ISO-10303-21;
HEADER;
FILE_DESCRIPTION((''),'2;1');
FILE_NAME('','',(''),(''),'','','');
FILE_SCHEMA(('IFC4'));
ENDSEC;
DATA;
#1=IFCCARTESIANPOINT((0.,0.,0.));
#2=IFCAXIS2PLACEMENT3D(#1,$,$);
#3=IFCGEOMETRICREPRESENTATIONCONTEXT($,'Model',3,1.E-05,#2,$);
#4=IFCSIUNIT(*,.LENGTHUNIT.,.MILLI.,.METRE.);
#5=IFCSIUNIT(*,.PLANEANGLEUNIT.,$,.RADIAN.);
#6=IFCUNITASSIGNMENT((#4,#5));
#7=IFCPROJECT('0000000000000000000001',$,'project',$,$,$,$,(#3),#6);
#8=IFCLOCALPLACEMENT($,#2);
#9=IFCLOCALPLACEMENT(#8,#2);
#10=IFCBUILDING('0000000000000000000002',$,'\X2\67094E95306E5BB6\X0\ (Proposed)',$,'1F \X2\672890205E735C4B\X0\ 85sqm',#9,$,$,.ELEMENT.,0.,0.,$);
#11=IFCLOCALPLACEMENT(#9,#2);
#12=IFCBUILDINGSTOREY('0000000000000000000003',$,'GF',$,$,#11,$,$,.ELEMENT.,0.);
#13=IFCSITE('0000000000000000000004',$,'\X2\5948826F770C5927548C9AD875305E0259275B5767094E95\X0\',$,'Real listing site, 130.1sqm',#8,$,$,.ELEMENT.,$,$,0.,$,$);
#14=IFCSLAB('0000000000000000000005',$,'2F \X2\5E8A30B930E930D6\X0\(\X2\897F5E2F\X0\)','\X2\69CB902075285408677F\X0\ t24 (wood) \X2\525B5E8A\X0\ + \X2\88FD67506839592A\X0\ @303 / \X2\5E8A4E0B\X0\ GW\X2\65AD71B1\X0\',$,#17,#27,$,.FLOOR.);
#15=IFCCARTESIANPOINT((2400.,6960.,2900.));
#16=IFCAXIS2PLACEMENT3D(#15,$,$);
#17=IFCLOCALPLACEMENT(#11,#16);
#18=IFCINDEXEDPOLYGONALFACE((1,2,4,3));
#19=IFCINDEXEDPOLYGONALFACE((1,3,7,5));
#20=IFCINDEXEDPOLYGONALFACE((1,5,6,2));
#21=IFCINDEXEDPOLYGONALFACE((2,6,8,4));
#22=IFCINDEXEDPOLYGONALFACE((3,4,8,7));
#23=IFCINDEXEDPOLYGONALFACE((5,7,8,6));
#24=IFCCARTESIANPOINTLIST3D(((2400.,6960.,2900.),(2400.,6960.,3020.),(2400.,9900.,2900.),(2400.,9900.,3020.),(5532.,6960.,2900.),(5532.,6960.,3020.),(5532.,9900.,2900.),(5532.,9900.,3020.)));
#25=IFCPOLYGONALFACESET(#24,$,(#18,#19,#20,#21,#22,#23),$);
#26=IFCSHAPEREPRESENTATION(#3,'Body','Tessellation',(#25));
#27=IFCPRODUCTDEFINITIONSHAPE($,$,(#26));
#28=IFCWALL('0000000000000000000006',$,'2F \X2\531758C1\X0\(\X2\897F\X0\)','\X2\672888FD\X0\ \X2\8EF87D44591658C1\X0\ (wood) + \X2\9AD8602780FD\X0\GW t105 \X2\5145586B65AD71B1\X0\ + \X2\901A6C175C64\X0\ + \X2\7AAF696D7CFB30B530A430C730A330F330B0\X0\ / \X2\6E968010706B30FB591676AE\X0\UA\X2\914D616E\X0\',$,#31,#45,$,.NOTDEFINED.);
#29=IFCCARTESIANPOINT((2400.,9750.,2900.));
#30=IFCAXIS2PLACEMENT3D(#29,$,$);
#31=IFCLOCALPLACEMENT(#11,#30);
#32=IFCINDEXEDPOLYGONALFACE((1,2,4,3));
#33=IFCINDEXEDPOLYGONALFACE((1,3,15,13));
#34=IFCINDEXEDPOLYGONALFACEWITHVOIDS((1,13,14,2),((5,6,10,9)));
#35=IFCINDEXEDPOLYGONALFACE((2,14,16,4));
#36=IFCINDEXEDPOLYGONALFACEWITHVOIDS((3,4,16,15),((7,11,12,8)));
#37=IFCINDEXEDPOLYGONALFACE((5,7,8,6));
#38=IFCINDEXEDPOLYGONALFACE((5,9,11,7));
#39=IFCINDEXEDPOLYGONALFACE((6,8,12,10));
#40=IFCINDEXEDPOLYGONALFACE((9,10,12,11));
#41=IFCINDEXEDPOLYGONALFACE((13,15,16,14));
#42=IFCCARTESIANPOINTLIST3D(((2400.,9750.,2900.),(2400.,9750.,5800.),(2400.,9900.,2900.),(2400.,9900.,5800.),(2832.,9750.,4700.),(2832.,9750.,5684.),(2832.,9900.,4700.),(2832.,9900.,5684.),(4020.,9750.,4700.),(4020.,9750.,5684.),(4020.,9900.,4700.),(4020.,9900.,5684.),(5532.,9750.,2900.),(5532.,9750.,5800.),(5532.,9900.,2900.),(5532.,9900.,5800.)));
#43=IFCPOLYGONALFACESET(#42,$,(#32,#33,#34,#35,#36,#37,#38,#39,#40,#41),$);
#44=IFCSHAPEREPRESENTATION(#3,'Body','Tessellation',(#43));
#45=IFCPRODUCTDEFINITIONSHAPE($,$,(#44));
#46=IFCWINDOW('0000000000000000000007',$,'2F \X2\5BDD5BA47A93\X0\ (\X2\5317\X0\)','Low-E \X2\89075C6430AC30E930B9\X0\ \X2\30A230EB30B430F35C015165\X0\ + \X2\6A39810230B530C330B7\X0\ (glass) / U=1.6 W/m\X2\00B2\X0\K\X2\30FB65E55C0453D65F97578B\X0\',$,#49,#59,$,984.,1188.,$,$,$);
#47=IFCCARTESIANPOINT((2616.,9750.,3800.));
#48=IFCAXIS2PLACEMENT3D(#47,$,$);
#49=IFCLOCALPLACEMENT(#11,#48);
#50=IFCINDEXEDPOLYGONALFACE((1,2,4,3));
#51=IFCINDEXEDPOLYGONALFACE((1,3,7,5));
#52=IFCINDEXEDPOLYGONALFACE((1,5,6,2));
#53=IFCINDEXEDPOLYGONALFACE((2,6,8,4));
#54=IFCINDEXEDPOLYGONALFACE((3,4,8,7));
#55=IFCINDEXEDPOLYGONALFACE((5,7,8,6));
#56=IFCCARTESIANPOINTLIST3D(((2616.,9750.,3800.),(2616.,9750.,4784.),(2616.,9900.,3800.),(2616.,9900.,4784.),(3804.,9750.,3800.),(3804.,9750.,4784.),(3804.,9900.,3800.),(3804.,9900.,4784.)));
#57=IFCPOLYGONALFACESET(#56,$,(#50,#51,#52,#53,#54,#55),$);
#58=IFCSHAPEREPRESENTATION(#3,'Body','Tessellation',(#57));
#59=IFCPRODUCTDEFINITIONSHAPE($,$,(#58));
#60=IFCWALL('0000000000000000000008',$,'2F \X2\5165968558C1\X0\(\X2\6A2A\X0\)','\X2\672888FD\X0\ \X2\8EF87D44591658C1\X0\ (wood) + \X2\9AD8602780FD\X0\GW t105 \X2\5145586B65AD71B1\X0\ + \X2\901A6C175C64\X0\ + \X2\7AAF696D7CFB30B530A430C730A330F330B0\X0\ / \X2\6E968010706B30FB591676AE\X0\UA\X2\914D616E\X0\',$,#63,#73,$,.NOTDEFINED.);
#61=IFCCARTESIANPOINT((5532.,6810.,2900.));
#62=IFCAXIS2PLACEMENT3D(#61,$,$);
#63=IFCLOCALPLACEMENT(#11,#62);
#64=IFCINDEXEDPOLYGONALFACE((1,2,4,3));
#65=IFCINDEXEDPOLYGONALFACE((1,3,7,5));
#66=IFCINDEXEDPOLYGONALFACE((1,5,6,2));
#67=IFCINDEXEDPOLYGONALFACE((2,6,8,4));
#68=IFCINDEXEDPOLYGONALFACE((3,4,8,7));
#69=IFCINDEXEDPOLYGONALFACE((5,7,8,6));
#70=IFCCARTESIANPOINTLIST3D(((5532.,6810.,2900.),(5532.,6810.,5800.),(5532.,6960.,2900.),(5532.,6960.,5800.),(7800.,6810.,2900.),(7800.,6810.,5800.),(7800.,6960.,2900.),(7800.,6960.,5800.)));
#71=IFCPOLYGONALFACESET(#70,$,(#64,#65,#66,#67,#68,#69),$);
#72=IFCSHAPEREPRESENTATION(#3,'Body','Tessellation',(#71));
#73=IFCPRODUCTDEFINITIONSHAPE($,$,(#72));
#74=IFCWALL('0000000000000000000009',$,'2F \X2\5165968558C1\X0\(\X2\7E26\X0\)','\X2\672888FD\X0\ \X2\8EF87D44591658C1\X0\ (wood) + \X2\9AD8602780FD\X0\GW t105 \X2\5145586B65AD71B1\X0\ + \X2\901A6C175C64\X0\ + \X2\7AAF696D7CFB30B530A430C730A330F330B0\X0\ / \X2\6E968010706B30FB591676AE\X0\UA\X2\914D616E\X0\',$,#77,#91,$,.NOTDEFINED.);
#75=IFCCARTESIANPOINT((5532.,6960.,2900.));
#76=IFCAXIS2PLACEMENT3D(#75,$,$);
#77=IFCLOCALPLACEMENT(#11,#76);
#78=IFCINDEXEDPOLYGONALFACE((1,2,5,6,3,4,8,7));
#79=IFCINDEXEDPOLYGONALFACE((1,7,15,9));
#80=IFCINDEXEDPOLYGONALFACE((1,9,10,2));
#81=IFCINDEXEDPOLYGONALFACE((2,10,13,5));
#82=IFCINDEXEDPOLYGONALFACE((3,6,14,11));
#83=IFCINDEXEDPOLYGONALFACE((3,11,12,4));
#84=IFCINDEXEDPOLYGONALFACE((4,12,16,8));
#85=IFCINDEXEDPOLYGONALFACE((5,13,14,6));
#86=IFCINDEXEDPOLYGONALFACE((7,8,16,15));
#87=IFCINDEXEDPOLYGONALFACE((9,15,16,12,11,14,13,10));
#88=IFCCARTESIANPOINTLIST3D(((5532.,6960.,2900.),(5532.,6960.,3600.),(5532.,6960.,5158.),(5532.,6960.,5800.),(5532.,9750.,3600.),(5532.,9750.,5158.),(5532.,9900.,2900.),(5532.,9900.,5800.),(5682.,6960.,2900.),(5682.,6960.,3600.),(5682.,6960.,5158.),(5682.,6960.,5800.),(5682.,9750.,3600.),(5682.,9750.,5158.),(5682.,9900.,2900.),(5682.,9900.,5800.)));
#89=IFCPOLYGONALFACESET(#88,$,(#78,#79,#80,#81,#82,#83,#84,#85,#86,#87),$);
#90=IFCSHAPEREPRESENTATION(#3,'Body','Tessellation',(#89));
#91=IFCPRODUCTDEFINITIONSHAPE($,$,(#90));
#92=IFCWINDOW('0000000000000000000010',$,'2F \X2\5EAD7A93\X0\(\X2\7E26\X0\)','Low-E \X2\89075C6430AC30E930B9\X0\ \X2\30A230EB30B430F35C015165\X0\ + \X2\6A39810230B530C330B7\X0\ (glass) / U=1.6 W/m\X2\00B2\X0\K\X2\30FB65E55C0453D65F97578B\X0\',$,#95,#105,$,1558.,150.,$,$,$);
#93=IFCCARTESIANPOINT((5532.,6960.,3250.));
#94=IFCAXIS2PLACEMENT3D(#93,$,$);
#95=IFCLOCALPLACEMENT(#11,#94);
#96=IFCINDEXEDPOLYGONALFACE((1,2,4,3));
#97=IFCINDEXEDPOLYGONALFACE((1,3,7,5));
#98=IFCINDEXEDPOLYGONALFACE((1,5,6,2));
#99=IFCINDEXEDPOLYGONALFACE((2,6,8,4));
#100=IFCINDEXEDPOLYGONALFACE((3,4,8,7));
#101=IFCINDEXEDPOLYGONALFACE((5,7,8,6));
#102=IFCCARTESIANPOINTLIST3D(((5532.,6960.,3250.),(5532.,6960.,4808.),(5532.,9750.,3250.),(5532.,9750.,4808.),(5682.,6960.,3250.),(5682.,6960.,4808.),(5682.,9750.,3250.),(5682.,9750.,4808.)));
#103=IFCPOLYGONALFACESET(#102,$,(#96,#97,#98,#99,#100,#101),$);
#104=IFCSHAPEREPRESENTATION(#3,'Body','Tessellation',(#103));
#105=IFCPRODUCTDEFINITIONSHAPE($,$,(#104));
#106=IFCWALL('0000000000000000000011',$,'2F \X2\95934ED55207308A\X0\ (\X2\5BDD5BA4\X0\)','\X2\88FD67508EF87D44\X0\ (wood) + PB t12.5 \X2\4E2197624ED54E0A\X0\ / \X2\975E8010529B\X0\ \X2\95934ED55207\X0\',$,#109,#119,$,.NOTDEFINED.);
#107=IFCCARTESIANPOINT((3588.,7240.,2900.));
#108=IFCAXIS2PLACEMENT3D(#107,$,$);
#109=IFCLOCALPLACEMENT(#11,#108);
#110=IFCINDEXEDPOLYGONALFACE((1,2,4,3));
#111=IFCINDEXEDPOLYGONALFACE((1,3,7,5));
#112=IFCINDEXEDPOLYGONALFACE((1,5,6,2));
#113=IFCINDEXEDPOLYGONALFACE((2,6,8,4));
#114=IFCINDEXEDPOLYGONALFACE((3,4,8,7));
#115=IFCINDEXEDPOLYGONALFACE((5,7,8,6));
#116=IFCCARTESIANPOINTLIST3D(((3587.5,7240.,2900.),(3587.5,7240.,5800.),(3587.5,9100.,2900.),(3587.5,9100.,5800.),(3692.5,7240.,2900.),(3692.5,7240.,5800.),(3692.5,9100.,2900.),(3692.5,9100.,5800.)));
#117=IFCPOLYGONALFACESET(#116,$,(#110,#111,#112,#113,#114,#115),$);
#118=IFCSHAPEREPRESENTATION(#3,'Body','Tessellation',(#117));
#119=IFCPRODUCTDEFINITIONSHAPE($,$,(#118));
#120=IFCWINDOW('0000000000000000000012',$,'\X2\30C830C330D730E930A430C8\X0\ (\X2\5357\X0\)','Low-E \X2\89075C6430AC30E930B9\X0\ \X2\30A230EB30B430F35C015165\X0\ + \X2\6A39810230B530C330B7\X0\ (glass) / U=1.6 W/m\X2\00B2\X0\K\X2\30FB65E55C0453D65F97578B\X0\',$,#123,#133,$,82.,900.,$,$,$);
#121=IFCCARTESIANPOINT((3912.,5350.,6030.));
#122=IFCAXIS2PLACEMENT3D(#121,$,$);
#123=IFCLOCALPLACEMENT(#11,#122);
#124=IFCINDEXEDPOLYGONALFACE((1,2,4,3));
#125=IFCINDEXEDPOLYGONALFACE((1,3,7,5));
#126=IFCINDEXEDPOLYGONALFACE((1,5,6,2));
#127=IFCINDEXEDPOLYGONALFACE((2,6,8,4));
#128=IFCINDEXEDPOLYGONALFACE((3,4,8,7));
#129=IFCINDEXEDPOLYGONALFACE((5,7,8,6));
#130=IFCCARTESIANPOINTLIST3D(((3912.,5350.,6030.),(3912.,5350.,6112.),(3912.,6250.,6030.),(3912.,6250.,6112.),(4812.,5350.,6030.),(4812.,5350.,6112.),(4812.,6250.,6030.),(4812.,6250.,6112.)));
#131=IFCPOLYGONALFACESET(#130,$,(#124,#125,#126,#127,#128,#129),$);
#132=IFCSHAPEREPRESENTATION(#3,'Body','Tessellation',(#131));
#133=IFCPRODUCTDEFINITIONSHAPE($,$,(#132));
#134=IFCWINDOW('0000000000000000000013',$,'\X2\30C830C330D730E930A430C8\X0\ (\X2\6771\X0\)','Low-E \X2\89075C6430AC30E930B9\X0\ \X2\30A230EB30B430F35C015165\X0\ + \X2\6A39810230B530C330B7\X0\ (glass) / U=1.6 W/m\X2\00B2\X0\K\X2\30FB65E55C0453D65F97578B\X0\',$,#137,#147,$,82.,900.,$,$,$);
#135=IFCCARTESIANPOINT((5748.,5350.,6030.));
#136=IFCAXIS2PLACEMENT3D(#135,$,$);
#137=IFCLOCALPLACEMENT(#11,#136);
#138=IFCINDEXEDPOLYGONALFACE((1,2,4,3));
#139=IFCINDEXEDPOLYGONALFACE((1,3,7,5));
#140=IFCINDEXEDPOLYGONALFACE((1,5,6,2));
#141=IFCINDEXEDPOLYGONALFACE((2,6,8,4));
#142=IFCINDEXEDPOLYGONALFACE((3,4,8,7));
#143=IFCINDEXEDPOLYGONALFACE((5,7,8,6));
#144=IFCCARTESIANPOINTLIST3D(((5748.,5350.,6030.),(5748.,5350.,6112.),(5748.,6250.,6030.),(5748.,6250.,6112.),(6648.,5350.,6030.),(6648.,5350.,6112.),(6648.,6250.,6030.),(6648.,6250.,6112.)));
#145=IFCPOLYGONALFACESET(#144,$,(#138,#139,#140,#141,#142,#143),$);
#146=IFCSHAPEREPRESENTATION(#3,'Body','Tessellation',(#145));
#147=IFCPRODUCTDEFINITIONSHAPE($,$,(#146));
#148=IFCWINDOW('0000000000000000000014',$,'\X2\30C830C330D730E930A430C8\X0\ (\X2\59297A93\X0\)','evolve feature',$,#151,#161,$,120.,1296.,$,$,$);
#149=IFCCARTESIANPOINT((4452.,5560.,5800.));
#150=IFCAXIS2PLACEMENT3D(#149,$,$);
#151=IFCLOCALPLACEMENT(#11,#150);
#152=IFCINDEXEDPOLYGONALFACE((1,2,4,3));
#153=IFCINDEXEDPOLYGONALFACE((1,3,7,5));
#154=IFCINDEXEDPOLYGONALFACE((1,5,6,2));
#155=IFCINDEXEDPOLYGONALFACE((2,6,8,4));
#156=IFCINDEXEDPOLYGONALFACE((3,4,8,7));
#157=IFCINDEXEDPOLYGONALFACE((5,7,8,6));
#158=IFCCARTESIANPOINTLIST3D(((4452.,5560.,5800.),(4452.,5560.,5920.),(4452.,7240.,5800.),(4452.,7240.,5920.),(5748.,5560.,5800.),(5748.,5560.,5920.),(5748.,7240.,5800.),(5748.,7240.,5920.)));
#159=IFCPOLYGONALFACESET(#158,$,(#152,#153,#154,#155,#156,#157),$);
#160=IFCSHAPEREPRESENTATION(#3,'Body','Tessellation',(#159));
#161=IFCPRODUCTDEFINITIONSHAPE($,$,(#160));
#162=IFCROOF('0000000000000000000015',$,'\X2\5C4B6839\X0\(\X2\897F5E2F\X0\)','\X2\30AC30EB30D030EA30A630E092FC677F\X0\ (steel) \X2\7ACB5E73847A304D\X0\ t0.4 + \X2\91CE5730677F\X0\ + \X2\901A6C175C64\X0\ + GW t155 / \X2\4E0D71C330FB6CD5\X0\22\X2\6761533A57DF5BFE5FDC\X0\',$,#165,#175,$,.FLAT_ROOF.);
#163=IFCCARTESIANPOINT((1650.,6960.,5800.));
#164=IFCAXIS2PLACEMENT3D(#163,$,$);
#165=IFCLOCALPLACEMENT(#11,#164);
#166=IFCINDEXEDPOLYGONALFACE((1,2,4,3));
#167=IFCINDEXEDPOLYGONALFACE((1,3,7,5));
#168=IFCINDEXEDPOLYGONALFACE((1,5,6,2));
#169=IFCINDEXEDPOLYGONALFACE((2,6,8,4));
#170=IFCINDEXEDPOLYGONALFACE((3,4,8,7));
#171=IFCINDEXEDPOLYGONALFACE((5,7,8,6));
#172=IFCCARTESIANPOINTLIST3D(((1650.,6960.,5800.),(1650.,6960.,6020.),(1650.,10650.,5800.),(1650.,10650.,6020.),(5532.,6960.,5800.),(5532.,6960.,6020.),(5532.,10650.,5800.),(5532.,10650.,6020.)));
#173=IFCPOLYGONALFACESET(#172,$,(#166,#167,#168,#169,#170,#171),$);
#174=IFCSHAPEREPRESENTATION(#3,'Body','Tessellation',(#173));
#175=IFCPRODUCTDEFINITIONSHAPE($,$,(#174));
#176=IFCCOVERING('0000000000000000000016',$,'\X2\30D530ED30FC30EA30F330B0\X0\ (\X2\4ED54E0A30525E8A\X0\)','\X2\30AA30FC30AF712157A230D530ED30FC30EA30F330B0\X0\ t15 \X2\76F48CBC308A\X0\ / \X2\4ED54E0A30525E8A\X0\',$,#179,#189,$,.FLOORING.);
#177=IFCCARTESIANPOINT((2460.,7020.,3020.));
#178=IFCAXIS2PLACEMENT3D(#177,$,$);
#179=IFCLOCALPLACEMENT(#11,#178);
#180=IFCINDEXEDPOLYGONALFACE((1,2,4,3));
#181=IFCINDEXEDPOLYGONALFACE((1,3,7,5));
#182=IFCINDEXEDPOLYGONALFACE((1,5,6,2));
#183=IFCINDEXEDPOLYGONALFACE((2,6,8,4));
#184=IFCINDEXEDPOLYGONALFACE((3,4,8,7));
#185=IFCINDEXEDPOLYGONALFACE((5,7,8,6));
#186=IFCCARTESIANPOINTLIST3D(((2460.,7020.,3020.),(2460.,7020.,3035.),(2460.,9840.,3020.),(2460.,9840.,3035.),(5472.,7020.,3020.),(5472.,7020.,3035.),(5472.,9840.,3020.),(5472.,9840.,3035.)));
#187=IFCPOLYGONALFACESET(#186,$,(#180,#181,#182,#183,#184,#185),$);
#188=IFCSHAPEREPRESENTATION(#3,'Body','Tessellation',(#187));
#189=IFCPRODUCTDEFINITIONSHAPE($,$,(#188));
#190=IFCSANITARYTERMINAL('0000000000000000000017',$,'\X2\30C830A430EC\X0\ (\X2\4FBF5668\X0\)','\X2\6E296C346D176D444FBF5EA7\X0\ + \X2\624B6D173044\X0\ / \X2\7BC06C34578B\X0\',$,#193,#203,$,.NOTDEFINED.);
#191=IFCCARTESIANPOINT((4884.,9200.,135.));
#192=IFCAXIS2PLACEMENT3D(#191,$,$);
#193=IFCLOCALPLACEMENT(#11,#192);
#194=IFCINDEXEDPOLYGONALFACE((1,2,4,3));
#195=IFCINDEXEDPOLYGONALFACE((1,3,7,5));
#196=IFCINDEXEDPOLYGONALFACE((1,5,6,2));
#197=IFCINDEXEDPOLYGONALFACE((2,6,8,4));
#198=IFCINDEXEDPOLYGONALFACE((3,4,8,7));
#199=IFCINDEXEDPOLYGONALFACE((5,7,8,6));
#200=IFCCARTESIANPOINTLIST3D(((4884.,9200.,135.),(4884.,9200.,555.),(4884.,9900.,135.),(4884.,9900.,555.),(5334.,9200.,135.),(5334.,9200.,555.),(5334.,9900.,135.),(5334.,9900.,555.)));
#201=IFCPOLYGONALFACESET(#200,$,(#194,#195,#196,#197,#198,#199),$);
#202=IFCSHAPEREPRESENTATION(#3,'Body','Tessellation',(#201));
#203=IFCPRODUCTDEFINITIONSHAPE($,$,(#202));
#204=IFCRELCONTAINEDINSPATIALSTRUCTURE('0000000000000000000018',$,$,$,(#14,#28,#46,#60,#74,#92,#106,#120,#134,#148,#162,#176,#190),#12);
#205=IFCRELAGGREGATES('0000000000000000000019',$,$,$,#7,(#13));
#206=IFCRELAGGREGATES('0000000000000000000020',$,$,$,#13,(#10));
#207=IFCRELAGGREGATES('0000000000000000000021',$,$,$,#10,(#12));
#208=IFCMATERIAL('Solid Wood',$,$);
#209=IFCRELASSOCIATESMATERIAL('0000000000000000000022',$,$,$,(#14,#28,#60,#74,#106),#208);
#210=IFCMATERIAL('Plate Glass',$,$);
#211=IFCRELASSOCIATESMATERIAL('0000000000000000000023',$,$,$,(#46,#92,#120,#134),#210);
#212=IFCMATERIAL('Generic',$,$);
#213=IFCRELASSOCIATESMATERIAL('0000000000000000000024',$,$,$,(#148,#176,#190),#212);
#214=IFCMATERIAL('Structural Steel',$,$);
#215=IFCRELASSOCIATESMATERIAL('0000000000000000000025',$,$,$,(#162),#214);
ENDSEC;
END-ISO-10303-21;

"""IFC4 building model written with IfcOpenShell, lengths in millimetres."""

from ifc_helpers import new_model, si_unit, frame, frame_2d, origin, place, context, project, spatial, rectangle, extrude, material, element, fill, save


model = new_model("IFC4")

# Units and contexts
model_context = context("Model", 3, precision=1e-05, world=origin())
ifc_project = project(units=[si_unit("LENGTHUNIT", "METRE", prefix="MILLI"), si_unit("PLANEANGLEUNIT", "RADIAN")], contexts=[model_context])

# Site, building, storey
site_placement = place(None, origin())
site = spatial("IfcSite", under=ifc_project, at=site_placement, Name="奈良県大和高田市大字有井", ObjectType="Real listing site, 130.1sqm", CompositionType="ELEMENT", RefElevation=0.0)
building_placement = place(site_placement, origin())
building = spatial("IfcBuilding", under=site, at=building_placement, Name="有井の家 (Proposed)", ObjectType="1F 木造平屋 85sqm", CompositionType="ELEMENT", ElevationOfRefHeight=0.0, ElevationOfTerrain=0.0)
storey_placement = place(building_placement, origin())
storey = spatial("IfcBuildingStorey", under=building, at=storey_placement, Name="GF", CompositionType="ELEMENT", Elevation=0.0)

# Slab
ifc_material_1 = material(Name="Solid Wood")
slab_placement = place(storey_placement, frame((2400.0, 6960.0, 2900.0)))
element("IfcSlab", 1, at=slab_placement, inside=storey, material=ifc_material_1, Name="2F 床スラブ(西帯)", Description="構造用合板 t24 (wood) 剛床 + 製材根太 @303 / 床下 GW断熱", PredefinedType="FLOOR", context=model_context, shape_type="SweptSolid", body=[
    extrude(rectangle(XDim=3132.0, YDim=2940.0, at=frame_2d((1566.0, 1470.0))), frame((2400.0, 6960.0, 2900.0)), (0.0, 0.0, 1.0), 120.0),
])

# Wall, opening, window
wall_1_placement = place(storey_placement, frame((2400.0, 9750.0, 2900.0)))
wall_1 = element("IfcWall", 2, at=wall_1_placement, inside=storey, material=ifc_material_1, Name="2F 北壁(西)", Description="木製 軸組外壁 (wood) + 高性能GW t105 充填断熱 + 通気層 + 窯業系サイディング / 準耐火・外皮UA配慮", PredefinedType="NOTDEFINED", context=model_context, shape_type="SweptSolid", body=[
    extrude(rectangle(XDim=3132.0, YDim=150.0, at=frame_2d((1566.0, 75.0))), frame((2400.0, 9750.0, 2900.0)), (0.0, 0.0, 1.0), 2900.0),
])
opening_1_placement = place(storey_placement, frame((2616.0, 9750.0, 3800.0)))
opening_1 = element("IfcOpeningElement", 3, at=opening_1_placement, cuts=wall_1, PredefinedType="NOTDEFINED", context=model_context, shape_type="SweptSolid", body=[
    extrude(rectangle(XDim=1188.0, YDim=150.0, at=frame_2d((594.0, 75.0))), frame((2616.0, 9750.0, 3800.0)), (0.0, 0.0, 1.0), 984.0),
])
ifc_material_2 = material(Name="Plate Glass")
window_1_placement = place(storey_placement, frame((2616.0, 9750.0, 3800.0)))
window_1 = element("IfcWindow", 4, at=window_1_placement, inside=storey, material=ifc_material_2, Name="2F 寝室窓 (北)", Description="Low-E 複層ガラス アルゴン封入 + 樹脂サッシ (glass) / U=1.6 W/m²K・日射取得型", OverallHeight=984.0, OverallWidth=1188.0, context=model_context, shape_type="SweptSolid", body=[
    extrude(rectangle(XDim=1188.0, YDim=150.0, at=frame_2d((594.0, 75.0))), frame((2616.0, 9750.0, 3800.0)), (0.0, 0.0, 1.0), 984.0),
])
fill(opening_1, window_1)

# Wall
wall_2_placement = place(storey_placement, frame((5532.0, 6810.0, 2900.0)))
element("IfcWall", 5, at=wall_2_placement, inside=storey, material=ifc_material_1, Name="2F 入隅壁(横)", Description="木製 軸組外壁 (wood) + 高性能GW t105 充填断熱 + 通気層 + 窯業系サイディング / 準耐火・外皮UA配慮", PredefinedType="NOTDEFINED", context=model_context, shape_type="SweptSolid", body=[
    extrude(rectangle(XDim=2268.0, YDim=150.0, at=frame_2d((1134.0, 75.0))), frame((5532.0, 6810.0, 2900.0)), (0.0, 0.0, 1.0), 2900.0),
])

# Wall, opening, window
wall_3_placement = place(storey_placement, frame((5532.0, 6960.0, 2900.0)))
wall_3 = element("IfcWall", 6, at=wall_3_placement, inside=storey, material=ifc_material_1, Name="2F 入隅壁(縦)", Description="木製 軸組外壁 (wood) + 高性能GW t105 充填断熱 + 通気層 + 窯業系サイディング / 準耐火・外皮UA配慮", PredefinedType="NOTDEFINED", context=model_context, shape_type="SweptSolid", body=[
    extrude(rectangle(XDim=150.0, YDim=2940.0, at=frame_2d((75.0, 1470.0))), frame((5532.0, 6960.0, 2900.0)), (0.0, 0.0, 1.0), 2900.0),
])
opening_2_placement = place(storey_placement, frame((5532.0, 6960.0, 3250.0)))
opening_2 = element("IfcOpeningElement", 7, at=opening_2_placement, cuts=wall_3, PredefinedType="NOTDEFINED", context=model_context, shape_type="SweptSolid", body=[
    extrude(rectangle(XDim=150.0, YDim=2790.0, at=frame_2d((75.0, 1395.0))), frame((5532.0, 6960.0, 3250.0)), (0.0, 0.0, 1.0), 1558.0),
])
window_2_placement = place(storey_placement, frame((5532.0, 6960.0, 3250.0)))
window_2 = element("IfcWindow", 8, at=window_2_placement, inside=storey, material=ifc_material_2, Name="2F 庭窓(縦)", Description="Low-E 複層ガラス アルゴン封入 + 樹脂サッシ (glass) / U=1.6 W/m²K・日射取得型", OverallHeight=1558.0, OverallWidth=150.0, context=model_context, shape_type="SweptSolid", body=[
    extrude(rectangle(XDim=150.0, YDim=2790.0, at=frame_2d((75.0, 1395.0))), frame((5532.0, 6960.0, 3250.0)), (0.0, 0.0, 1.0), 1558.0),
])
fill(opening_2, window_2)

# Wall
wall_4_placement = place(storey_placement, frame((3588.0, 7240.0, 2900.0)))
element("IfcWall", 9, at=wall_4_placement, inside=storey, material=ifc_material_1, Name="2F 間仕切り (寝室)", Description="製材軸組 (wood) + PB t12.5 両面仕上 / 非耐力 間仕切", PredefinedType="NOTDEFINED", context=model_context, shape_type="SweptSolid", body=[
    extrude(rectangle(XDim=105.0, YDim=1860.0, at=frame_2d((52.0, 930.0))), frame((3588.0, 7240.0, 2900.0)), (0.0, 0.0, 1.0), 2900.0),
])

# Windows
window_3_placement = place(storey_placement, frame((3912.0, 5350.0, 6030.0)))
element("IfcWindow", 10, at=window_3_placement, inside=storey, material=ifc_material_2, Name="トップライト (南)", Description="Low-E 複層ガラス アルゴン封入 + 樹脂サッシ (glass) / U=1.6 W/m²K・日射取得型", OverallHeight=82.0, OverallWidth=900.0, context=model_context, shape_type="SweptSolid", body=[
    extrude(rectangle(XDim=900.0, YDim=900.0, at=frame_2d((450.0, 450.0))), frame((3912.0, 5350.0, 6030.0)), (0.0, 0.0, 1.0), 82.0),
])
window_4_placement = place(storey_placement, frame((5748.0, 5350.0, 6030.0)))
element("IfcWindow", 11, at=window_4_placement, inside=storey, material=ifc_material_2, Name="トップライト (東)", Description="Low-E 複層ガラス アルゴン封入 + 樹脂サッシ (glass) / U=1.6 W/m²K・日射取得型", OverallHeight=82.0, OverallWidth=900.0, context=model_context, shape_type="SweptSolid", body=[
    extrude(rectangle(XDim=900.0, YDim=900.0, at=frame_2d((450.0, 450.0))), frame((5748.0, 5350.0, 6030.0)), (0.0, 0.0, 1.0), 82.0),
])
ifc_material_3 = material(Name="Generic")
window_5_placement = place(storey_placement, frame((4452.0, 5560.0, 5800.0)))
element("IfcWindow", 12, at=window_5_placement, inside=storey, material=ifc_material_3, Name="トップライト (天窓)", Description="evolve feature", OverallHeight=120.0, OverallWidth=1296.0, context=model_context, shape_type="SweptSolid", body=[
    extrude(rectangle(XDim=1296.0, YDim=1680.0, at=frame_2d((648.0, 840.0))), frame((4452.0, 5560.0, 5800.0)), (0.0, 0.0, 1.0), 120.0),
])

# Roof
ifc_material_4 = material(Name="Structural Steel")
for number, where, name in (
    (13, (1650.0, 6960.0, 5800.0), "屋根(西帯)"),
):
    element("IfcRoof", number, at=place(storey_placement, frame(where)), inside=storey, material=ifc_material_4, Name=name, Description="ガルバリウム鋼板 (steel) 立平葺き t0.4 + 野地板 + 通気層 + GW t155 / 不燃・法22条区域対応", PredefinedType="FLAT_ROOF", context=model_context, shape_type="SweptSolid", body=[
        extrude(rectangle(XDim=3882.0, YDim=3690.0, at=frame_2d((1941.0, 1845.0))), frame((1650.0, 6960.0, 5800.0)), (0.0, 0.0, 1.0), 220.0),
    ])

# Covering
covering_placement = place(storey_placement, frame((2460.0, 7020.0, 3020.0)))
element("IfcCovering", 14, at=covering_placement, inside=storey, material=ifc_material_3, Name="フローリング (仕上げ床)", Description="オーク無垢フローリング t15 直貼り / 仕上げ床", PredefinedType="FLOORING", context=model_context, shape_type="SweptSolid", body=[
    extrude(rectangle(XDim=3012.0, YDim=2820.0, at=frame_2d((1506.0, 1410.0))), frame((2460.0, 7020.0, 3020.0)), (0.0, 0.0, 1.0), 15.0),
])

# Sanitary terminal
sanitary_terminal_placement = place(storey_placement, frame((4884.0, 9200.0, 135.0)))
element("IfcSanitaryTerminal", 15, at=sanitary_terminal_placement, inside=storey, material=ifc_material_3, Name="トイレ (便器)", Description="温水洗浄便座 + 手洗い / 節水型", PredefinedType="NOTDEFINED", context=model_context, shape_type="SweptSolid", body=[
    extrude(rectangle(XDim=450.0, YDim=700.0, at=frame_2d((225.0, 350.0))), frame((4884.0, 9200.0, 135.0)), (0.0, 0.0, 1.0), 420.0),
])

save(model, "model.ifc")
